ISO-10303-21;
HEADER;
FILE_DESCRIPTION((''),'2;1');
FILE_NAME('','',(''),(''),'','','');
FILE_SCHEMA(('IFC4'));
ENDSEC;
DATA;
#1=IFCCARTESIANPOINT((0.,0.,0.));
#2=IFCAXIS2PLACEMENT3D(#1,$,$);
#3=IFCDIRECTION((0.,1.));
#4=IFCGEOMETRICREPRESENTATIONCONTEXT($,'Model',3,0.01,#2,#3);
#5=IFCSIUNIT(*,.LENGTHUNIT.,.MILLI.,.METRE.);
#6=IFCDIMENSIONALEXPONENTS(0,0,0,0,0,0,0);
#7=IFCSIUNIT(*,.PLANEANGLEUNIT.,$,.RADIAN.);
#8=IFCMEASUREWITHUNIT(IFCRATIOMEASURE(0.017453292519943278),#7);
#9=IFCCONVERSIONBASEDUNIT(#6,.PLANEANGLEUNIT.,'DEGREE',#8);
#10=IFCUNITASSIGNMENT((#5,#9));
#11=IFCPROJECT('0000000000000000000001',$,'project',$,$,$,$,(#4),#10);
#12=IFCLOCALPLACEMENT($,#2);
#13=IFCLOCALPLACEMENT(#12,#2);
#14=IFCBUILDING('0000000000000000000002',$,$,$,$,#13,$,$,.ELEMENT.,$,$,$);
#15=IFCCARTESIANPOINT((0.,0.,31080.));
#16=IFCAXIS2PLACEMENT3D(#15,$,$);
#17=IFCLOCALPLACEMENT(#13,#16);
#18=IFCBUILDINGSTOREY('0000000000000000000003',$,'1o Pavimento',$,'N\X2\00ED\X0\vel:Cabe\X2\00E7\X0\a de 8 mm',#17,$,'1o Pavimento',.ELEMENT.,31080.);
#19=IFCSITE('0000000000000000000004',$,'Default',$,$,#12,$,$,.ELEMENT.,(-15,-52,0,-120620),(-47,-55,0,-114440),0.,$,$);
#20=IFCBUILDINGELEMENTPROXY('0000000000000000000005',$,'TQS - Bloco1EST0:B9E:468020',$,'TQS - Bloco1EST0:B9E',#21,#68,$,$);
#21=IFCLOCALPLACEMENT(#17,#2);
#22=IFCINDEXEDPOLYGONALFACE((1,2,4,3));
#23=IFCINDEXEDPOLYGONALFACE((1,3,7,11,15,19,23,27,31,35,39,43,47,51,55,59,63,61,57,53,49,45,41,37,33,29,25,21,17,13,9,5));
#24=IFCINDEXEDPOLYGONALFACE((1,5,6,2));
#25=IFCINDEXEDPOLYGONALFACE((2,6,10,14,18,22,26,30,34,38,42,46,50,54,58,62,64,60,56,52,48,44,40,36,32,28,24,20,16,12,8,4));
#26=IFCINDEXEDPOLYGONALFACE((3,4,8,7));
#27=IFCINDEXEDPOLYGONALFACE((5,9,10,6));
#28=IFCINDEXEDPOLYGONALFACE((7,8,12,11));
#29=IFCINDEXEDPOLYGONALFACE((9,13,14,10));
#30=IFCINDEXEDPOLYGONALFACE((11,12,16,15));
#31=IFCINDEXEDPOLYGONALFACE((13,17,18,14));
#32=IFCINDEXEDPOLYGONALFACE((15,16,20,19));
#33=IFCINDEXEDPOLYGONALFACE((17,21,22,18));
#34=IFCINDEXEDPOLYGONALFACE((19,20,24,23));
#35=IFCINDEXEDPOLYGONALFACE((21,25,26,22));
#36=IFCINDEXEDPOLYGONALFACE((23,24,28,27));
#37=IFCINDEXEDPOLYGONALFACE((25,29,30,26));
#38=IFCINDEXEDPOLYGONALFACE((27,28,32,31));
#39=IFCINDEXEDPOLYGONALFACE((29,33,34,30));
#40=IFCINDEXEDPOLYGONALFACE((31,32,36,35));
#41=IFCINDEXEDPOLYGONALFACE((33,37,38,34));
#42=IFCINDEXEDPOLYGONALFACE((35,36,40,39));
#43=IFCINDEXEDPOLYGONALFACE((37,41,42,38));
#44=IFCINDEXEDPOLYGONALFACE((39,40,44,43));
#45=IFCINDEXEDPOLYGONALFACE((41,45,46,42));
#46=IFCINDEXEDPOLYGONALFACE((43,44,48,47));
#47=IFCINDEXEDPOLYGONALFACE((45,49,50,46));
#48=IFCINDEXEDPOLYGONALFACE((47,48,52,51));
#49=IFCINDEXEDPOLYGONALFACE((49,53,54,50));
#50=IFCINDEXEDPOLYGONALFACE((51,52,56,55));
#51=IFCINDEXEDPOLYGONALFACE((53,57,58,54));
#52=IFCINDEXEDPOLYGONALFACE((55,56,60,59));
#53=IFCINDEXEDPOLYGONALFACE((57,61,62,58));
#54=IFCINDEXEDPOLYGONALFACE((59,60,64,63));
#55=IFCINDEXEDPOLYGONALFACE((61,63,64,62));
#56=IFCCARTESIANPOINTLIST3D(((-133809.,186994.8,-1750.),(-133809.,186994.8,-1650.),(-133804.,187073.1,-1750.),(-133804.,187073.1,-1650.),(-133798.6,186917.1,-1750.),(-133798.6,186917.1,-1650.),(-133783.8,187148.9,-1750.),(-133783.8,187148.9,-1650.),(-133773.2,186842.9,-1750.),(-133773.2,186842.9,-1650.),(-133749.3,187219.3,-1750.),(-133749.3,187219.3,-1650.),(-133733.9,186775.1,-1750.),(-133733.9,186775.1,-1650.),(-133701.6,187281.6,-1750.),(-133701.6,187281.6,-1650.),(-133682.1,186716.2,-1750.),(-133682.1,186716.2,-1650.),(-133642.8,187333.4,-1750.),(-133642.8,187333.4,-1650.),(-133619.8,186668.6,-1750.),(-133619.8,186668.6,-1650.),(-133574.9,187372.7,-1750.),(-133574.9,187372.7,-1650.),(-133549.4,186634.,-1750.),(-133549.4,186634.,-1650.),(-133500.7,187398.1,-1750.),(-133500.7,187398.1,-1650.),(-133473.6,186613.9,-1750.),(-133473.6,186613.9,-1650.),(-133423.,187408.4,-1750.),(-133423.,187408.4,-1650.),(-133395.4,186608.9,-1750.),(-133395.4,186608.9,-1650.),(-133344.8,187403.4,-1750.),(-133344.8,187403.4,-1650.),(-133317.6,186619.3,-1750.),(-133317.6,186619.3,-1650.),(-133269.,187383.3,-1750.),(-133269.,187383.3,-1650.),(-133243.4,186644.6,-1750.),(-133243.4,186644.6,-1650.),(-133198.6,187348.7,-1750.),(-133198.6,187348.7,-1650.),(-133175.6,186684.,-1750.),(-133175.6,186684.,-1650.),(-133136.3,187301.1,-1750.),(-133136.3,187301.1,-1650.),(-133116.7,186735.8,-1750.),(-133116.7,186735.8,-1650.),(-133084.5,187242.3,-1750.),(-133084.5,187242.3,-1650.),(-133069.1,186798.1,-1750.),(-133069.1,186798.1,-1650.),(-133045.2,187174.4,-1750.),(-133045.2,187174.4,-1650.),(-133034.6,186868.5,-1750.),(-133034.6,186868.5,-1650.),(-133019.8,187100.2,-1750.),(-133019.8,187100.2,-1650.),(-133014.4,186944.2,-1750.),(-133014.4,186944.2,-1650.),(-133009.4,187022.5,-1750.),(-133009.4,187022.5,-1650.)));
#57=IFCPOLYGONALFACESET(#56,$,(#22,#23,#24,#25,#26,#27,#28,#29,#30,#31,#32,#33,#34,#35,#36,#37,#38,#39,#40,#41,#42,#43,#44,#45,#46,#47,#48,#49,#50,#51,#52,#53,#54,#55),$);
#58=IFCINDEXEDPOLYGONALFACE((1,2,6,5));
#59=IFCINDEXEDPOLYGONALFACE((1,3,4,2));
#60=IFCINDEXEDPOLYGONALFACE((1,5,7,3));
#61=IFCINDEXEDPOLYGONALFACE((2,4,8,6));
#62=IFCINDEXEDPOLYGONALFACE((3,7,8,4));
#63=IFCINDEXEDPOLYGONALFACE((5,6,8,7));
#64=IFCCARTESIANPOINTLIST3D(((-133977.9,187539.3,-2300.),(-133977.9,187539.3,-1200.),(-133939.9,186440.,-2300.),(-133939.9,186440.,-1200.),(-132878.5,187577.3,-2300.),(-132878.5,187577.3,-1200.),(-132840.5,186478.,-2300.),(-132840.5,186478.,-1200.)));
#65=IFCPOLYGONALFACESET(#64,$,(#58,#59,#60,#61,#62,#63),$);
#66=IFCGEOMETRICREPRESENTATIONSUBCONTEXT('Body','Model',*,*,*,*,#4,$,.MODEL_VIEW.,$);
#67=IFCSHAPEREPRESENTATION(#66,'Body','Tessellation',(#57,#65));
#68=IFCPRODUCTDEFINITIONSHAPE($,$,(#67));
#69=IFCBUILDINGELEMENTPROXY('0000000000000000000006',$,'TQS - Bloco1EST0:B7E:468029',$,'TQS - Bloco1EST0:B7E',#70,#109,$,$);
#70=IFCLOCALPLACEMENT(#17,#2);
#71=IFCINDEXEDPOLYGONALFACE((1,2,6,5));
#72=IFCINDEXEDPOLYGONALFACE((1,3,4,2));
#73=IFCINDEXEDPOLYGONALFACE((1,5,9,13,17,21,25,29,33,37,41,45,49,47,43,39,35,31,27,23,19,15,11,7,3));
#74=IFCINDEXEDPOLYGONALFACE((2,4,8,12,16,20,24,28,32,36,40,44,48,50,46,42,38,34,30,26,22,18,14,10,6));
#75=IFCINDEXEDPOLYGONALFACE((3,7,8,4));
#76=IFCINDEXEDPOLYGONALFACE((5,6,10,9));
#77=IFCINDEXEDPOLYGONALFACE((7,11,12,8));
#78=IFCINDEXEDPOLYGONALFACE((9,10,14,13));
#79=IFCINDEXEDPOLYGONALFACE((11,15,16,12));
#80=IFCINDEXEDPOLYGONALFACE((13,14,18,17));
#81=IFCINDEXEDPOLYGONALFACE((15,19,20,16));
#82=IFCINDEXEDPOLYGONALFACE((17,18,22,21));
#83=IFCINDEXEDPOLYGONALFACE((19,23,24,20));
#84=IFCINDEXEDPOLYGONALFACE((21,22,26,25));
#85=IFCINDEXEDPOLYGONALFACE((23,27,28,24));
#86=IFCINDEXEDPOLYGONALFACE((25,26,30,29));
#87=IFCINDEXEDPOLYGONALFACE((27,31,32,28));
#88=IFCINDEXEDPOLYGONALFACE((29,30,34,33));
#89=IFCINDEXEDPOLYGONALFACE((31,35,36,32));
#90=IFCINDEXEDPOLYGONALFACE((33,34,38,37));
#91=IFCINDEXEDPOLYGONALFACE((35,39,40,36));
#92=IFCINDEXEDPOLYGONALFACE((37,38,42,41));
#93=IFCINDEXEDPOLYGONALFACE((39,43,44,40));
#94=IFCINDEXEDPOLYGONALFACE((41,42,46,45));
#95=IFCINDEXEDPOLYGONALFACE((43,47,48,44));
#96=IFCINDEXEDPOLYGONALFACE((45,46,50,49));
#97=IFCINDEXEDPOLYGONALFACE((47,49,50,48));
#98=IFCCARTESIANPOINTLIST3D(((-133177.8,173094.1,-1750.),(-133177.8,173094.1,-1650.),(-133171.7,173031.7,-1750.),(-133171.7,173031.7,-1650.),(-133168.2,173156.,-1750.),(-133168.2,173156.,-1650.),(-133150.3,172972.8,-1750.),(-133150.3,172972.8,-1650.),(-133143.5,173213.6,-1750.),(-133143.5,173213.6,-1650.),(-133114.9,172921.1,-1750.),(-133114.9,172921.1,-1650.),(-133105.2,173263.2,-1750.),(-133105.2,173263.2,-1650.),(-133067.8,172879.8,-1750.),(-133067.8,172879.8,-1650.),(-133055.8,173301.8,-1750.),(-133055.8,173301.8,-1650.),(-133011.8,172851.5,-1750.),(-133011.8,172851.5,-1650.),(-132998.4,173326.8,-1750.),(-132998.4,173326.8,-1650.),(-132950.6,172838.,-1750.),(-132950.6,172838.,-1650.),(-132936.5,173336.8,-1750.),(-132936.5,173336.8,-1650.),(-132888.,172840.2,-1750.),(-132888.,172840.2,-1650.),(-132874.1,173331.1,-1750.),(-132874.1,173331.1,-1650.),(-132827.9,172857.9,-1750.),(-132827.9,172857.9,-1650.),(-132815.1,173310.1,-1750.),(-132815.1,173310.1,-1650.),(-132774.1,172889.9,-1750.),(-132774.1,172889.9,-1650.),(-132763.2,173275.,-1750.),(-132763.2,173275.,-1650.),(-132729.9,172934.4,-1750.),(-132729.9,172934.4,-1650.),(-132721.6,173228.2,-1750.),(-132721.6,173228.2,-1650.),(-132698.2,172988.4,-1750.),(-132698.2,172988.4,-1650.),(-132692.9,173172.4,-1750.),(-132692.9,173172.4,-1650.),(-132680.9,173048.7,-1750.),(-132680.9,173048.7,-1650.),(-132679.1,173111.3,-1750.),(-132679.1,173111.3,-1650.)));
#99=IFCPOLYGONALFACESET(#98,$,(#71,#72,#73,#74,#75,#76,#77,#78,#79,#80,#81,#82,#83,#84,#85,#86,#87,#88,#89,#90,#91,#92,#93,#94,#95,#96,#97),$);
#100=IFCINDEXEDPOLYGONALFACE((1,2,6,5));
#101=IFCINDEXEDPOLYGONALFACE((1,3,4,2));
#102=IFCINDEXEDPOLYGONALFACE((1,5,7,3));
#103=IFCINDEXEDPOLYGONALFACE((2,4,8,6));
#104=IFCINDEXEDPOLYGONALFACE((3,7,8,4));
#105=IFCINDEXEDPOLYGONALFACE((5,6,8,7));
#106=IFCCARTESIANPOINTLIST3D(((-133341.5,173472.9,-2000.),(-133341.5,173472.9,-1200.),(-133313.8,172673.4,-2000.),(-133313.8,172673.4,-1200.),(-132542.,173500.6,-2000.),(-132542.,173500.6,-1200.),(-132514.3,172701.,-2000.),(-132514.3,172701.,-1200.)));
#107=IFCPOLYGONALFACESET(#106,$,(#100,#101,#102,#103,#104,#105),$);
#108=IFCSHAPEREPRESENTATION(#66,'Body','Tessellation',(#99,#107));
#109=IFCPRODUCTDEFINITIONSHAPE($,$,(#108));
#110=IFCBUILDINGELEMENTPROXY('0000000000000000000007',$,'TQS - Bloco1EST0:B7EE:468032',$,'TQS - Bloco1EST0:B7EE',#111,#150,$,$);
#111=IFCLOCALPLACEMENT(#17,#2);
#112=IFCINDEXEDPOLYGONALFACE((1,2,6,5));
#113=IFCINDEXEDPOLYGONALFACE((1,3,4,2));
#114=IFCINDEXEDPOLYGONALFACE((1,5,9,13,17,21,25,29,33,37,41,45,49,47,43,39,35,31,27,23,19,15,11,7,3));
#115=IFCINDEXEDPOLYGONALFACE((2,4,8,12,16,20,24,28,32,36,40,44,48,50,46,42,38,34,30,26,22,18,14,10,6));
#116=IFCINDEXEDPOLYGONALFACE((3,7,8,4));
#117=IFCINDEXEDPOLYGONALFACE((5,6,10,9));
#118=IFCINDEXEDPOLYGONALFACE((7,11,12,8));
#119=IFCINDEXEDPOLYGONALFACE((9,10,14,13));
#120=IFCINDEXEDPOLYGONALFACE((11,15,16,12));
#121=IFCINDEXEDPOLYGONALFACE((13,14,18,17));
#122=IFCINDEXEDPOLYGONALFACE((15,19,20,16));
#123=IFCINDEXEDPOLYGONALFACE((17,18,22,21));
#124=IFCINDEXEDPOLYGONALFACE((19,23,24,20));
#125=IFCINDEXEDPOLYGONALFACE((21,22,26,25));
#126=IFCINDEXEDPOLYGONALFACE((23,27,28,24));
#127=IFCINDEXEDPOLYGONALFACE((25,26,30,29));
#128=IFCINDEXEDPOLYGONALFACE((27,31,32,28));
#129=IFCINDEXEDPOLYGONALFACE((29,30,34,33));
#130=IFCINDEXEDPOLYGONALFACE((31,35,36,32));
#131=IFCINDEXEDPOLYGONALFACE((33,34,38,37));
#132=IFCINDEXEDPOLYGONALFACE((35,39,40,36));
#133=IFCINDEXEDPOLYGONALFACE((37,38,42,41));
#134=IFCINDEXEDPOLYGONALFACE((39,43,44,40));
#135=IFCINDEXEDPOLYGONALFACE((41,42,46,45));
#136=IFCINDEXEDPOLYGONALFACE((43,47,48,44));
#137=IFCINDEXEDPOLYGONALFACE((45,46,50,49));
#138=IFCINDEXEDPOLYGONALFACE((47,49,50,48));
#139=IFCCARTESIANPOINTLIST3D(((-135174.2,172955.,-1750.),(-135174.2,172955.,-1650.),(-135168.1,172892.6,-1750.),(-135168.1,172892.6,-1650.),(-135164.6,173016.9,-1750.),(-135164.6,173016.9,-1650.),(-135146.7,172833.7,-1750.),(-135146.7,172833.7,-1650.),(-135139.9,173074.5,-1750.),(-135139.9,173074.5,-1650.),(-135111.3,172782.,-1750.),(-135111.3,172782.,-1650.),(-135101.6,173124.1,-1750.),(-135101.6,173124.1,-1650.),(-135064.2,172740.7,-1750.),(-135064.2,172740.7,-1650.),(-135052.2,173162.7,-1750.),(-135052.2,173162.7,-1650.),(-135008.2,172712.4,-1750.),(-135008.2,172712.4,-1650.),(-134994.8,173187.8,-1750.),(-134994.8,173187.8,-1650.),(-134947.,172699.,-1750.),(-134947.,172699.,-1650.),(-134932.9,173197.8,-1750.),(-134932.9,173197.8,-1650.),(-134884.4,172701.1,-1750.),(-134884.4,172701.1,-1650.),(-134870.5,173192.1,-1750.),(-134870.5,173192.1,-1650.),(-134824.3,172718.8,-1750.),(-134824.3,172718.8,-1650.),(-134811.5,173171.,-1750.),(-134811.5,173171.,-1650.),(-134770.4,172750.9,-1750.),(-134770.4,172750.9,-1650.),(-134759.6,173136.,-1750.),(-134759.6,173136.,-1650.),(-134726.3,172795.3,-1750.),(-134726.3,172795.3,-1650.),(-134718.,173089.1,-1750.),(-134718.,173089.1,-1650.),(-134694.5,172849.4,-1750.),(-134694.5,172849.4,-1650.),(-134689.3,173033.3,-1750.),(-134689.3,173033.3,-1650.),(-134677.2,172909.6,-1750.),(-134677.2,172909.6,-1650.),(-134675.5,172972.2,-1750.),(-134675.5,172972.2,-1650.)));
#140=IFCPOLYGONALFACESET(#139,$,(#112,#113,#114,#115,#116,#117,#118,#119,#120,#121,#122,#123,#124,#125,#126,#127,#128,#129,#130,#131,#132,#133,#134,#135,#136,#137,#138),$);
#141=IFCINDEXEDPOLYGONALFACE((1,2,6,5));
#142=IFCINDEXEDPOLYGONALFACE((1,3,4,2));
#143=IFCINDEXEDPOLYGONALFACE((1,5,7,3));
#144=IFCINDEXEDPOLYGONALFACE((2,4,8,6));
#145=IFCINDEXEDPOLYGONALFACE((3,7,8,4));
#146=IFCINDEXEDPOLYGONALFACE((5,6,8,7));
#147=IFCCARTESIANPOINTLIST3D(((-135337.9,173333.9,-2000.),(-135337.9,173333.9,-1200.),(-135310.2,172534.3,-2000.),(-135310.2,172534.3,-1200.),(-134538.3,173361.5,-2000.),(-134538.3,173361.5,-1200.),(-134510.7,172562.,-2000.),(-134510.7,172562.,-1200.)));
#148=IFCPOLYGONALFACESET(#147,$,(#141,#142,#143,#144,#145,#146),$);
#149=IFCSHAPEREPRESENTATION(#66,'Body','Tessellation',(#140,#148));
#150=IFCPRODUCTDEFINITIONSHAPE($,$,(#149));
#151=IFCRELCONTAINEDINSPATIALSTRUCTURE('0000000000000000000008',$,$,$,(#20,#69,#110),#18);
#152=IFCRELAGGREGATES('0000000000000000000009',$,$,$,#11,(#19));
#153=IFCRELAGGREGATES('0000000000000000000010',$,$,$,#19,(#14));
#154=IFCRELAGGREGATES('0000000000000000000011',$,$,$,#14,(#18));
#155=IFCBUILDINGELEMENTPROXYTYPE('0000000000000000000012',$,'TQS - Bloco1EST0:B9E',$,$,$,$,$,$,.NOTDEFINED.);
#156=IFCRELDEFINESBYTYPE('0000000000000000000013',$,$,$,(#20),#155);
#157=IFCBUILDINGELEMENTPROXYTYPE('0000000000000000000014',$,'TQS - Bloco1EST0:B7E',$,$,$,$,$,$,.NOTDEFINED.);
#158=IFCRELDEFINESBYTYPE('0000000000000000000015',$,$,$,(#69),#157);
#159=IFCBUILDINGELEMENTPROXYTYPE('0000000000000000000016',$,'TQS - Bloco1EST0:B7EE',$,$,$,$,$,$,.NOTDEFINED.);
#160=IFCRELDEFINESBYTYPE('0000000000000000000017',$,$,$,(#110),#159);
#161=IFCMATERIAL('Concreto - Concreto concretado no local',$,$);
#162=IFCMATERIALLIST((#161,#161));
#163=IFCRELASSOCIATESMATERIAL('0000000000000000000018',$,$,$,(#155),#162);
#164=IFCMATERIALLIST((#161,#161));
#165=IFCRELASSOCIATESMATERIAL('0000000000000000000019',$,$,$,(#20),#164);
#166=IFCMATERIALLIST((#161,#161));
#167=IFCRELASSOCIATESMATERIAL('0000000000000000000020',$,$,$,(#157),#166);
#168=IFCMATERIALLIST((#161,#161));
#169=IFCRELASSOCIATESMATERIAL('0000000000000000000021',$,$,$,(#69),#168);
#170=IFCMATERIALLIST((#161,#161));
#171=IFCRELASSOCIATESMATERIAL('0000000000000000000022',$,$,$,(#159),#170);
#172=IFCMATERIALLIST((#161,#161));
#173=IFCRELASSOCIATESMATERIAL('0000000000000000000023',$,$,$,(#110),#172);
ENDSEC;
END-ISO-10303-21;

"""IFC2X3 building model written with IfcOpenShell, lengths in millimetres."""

from ifc_helpers import new_model, entity, si_unit, converted_unit, direction, frame, frame_2d, origin, origin_2d_with_axis, place, context, subcontext, project, spatial, rectangle, circle, extrude, source, transform, mapped, material, material_list, type_object, type_shapes, element, save


model = new_model("IFC2X3")

# Units and contexts
model_context = context("Model", 3, precision=0.01, world=origin(), true_north=direction((0.0, 1.0)))
body_context = subcontext(model_context, "Body", "Model", "MODEL_VIEW")
ifc_project = project(units=[si_unit("LENGTHUNIT", "METRE", prefix="MILLI"), converted_unit("PLANEANGLEUNIT", "DEGREE", entity("IfcRatioMeasure", 0.017453292519943278), si_unit("PLANEANGLEUNIT", "RADIAN"), dimensions=[0, 0, 0, 0, 0, 0, 0])], contexts=[model_context])

# Site, building, storey
site_placement = place(None, origin())
site = spatial("IfcSite", under=ifc_project, at=site_placement, Name="Default", CompositionType="ELEMENT", RefLatitude=(-15, -52, 0, -120620), RefLongitude=(-47, -55, 0, -114440), RefElevation=0.0)
building_placement = place(site_placement, origin())
building = spatial("IfcBuilding", under=site, at=building_placement, CompositionType="ELEMENT")
storey_placement = place(building_placement, frame((0.0, 0.0, 31080.0)))
storey = spatial("IfcBuildingStorey", under=building, at=storey_placement, Name="1o Pavimento", ObjectType="Nível:Cabeça de 8 mm", LongName="1o Pavimento", CompositionType="ELEMENT", Elevation=31080.0)

# Building element proxies
ifc_material_1 = material(Name="Concreto - Concreto concretado no local")
ifc_material_list_1 = material_list([ifc_material_1, ifc_material_1])
ifc_material_list_2 = material_list([ifc_material_1, ifc_material_1])
building_element_proxy_type_1 = type_object("IfcBuildingElementProxyType", Name="TQS - Bloco1EST0:B9E", PredefinedType="NOTDEFINED", material=ifc_material_list_2)
shared_shape_1 = source(origin(), body_context, "Body", "SweptSolid", [
    extrude(circle(Radius=400.0, at=frame_2d((0.0, 0.0), x_axis=(1.0, 0.0))), frame((0.0, 0.0, -550.0)), (0.0, 0.0, 1.0), 100.0),
    extrude(rectangle(XDim=1100.0, YDim=1100.0, at=origin_2d_with_axis()), frame((0.0, 0.0, -1100.0), z_axis=(0.0, 0.0, 1.0), x_axis=(-1.0, 0.0, 0.0)), (0.0, 0.0, 1.0), 1100.0),
])
type_shapes(building_element_proxy_type_1, [shared_shape_1])
proxy_1_placement = place(storey_placement, frame((-133409.2, 187008.7, -1200.0), z_axis=(0.0, 0.0, 1.0), x_axis=(-0.034551, 0.999403, 0.0)))
element("IfcBuildingElementProxy", 1, at=proxy_1_placement, inside=storey, type_object=building_element_proxy_type_1, material=ifc_material_list_1, Name="TQS - Bloco1EST0:B9E:468020", ObjectType="TQS - Bloco1EST0:B9E", context=body_context, shape_type="MappedRepresentation", body=[
    mapped(shared_shape_1, transform((0.0, 0.0, 0.0), scale=1.0)),
])
ifc_material_list_3 = material_list([ifc_material_1, ifc_material_1])
ifc_material_list_4 = material_list([ifc_material_1, ifc_material_1])
building_element_proxy_type_2 = type_object("IfcBuildingElementProxyType", Name="TQS - Bloco1EST0:B7E", PredefinedType="NOTDEFINED", material=ifc_material_list_4)
shared_shape_2 = source(origin(), body_context, "Body", "SweptSolid", [
    extrude(circle(Radius=250.0, at=frame_2d((0.0, 0.0), x_axis=(1.0, 0.0))), frame((0.0, 0.0, -550.0)), (0.0, 0.0, 1.0), 100.0),
    extrude(rectangle(XDim=800.0, YDim=800.0, at=origin_2d_with_axis()), frame((0.0, 0.0, -800.0), z_axis=(0.0, 0.0, 1.0), x_axis=(-1.0, 0.0, 0.0)), (0.0, 0.0, 1.0), 800.0),
])
type_shapes(building_element_proxy_type_2, [shared_shape_2])
proxy_2_placement = place(storey_placement, frame((-132927.9, 173087.0, -1200.0), z_axis=(0.0, 0.0, 1.0), x_axis=(-0.034551, 0.999403, 0.0)))
element("IfcBuildingElementProxy", 2, at=proxy_2_placement, inside=storey, type_object=building_element_proxy_type_2, material=ifc_material_list_3, Name="TQS - Bloco1EST0:B7E:468029", ObjectType="TQS - Bloco1EST0:B7E", context=body_context, shape_type="MappedRepresentation", body=[
    mapped(shared_shape_2, transform((0.0, 0.0, 0.0), scale=1.0)),
])
ifc_material_list_5 = material_list([ifc_material_1, ifc_material_1])
ifc_material_list_6 = material_list([ifc_material_1, ifc_material_1])
building_element_proxy_type_3 = type_object("IfcBuildingElementProxyType", Name="TQS - Bloco1EST0:B7EE", PredefinedType="NOTDEFINED", material=ifc_material_list_6)
shared_shape_3 = source(origin(), body_context, "Body", "SweptSolid", [
    extrude(circle(Radius=250.0, at=frame_2d((0.0, 0.0), x_axis=(1.0, 0.0))), frame((0.0, 0.0, -550.0)), (0.0, 0.0, 1.0), 100.0),
    extrude(rectangle(XDim=800.0, YDim=800.0, at=origin_2d_with_axis()), frame((0.0, 0.0, -800.0), z_axis=(0.0, 0.0, 1.0), x_axis=(-1.0, 0.0, 0.0)), (0.0, 0.0, 1.0), 800.0),
])
type_shapes(building_element_proxy_type_3, [shared_shape_3])
proxy_3_placement = place(storey_placement, frame((-134924.3, 172947.9, -1200.0), z_axis=(0.0, 0.0, 1.0), x_axis=(-0.034551, 0.999403, 0.0)))
element("IfcBuildingElementProxy", 3, at=proxy_3_placement, inside=storey, type_object=building_element_proxy_type_3, material=ifc_material_list_5, Name="TQS - Bloco1EST0:B7EE:468032", ObjectType="TQS - Bloco1EST0:B7EE", context=body_context, shape_type="MappedRepresentation", body=[
    mapped(shared_shape_3, transform((0.0, 0.0, 0.0), scale=1.0)),
])

save(model, "model.ifc")
